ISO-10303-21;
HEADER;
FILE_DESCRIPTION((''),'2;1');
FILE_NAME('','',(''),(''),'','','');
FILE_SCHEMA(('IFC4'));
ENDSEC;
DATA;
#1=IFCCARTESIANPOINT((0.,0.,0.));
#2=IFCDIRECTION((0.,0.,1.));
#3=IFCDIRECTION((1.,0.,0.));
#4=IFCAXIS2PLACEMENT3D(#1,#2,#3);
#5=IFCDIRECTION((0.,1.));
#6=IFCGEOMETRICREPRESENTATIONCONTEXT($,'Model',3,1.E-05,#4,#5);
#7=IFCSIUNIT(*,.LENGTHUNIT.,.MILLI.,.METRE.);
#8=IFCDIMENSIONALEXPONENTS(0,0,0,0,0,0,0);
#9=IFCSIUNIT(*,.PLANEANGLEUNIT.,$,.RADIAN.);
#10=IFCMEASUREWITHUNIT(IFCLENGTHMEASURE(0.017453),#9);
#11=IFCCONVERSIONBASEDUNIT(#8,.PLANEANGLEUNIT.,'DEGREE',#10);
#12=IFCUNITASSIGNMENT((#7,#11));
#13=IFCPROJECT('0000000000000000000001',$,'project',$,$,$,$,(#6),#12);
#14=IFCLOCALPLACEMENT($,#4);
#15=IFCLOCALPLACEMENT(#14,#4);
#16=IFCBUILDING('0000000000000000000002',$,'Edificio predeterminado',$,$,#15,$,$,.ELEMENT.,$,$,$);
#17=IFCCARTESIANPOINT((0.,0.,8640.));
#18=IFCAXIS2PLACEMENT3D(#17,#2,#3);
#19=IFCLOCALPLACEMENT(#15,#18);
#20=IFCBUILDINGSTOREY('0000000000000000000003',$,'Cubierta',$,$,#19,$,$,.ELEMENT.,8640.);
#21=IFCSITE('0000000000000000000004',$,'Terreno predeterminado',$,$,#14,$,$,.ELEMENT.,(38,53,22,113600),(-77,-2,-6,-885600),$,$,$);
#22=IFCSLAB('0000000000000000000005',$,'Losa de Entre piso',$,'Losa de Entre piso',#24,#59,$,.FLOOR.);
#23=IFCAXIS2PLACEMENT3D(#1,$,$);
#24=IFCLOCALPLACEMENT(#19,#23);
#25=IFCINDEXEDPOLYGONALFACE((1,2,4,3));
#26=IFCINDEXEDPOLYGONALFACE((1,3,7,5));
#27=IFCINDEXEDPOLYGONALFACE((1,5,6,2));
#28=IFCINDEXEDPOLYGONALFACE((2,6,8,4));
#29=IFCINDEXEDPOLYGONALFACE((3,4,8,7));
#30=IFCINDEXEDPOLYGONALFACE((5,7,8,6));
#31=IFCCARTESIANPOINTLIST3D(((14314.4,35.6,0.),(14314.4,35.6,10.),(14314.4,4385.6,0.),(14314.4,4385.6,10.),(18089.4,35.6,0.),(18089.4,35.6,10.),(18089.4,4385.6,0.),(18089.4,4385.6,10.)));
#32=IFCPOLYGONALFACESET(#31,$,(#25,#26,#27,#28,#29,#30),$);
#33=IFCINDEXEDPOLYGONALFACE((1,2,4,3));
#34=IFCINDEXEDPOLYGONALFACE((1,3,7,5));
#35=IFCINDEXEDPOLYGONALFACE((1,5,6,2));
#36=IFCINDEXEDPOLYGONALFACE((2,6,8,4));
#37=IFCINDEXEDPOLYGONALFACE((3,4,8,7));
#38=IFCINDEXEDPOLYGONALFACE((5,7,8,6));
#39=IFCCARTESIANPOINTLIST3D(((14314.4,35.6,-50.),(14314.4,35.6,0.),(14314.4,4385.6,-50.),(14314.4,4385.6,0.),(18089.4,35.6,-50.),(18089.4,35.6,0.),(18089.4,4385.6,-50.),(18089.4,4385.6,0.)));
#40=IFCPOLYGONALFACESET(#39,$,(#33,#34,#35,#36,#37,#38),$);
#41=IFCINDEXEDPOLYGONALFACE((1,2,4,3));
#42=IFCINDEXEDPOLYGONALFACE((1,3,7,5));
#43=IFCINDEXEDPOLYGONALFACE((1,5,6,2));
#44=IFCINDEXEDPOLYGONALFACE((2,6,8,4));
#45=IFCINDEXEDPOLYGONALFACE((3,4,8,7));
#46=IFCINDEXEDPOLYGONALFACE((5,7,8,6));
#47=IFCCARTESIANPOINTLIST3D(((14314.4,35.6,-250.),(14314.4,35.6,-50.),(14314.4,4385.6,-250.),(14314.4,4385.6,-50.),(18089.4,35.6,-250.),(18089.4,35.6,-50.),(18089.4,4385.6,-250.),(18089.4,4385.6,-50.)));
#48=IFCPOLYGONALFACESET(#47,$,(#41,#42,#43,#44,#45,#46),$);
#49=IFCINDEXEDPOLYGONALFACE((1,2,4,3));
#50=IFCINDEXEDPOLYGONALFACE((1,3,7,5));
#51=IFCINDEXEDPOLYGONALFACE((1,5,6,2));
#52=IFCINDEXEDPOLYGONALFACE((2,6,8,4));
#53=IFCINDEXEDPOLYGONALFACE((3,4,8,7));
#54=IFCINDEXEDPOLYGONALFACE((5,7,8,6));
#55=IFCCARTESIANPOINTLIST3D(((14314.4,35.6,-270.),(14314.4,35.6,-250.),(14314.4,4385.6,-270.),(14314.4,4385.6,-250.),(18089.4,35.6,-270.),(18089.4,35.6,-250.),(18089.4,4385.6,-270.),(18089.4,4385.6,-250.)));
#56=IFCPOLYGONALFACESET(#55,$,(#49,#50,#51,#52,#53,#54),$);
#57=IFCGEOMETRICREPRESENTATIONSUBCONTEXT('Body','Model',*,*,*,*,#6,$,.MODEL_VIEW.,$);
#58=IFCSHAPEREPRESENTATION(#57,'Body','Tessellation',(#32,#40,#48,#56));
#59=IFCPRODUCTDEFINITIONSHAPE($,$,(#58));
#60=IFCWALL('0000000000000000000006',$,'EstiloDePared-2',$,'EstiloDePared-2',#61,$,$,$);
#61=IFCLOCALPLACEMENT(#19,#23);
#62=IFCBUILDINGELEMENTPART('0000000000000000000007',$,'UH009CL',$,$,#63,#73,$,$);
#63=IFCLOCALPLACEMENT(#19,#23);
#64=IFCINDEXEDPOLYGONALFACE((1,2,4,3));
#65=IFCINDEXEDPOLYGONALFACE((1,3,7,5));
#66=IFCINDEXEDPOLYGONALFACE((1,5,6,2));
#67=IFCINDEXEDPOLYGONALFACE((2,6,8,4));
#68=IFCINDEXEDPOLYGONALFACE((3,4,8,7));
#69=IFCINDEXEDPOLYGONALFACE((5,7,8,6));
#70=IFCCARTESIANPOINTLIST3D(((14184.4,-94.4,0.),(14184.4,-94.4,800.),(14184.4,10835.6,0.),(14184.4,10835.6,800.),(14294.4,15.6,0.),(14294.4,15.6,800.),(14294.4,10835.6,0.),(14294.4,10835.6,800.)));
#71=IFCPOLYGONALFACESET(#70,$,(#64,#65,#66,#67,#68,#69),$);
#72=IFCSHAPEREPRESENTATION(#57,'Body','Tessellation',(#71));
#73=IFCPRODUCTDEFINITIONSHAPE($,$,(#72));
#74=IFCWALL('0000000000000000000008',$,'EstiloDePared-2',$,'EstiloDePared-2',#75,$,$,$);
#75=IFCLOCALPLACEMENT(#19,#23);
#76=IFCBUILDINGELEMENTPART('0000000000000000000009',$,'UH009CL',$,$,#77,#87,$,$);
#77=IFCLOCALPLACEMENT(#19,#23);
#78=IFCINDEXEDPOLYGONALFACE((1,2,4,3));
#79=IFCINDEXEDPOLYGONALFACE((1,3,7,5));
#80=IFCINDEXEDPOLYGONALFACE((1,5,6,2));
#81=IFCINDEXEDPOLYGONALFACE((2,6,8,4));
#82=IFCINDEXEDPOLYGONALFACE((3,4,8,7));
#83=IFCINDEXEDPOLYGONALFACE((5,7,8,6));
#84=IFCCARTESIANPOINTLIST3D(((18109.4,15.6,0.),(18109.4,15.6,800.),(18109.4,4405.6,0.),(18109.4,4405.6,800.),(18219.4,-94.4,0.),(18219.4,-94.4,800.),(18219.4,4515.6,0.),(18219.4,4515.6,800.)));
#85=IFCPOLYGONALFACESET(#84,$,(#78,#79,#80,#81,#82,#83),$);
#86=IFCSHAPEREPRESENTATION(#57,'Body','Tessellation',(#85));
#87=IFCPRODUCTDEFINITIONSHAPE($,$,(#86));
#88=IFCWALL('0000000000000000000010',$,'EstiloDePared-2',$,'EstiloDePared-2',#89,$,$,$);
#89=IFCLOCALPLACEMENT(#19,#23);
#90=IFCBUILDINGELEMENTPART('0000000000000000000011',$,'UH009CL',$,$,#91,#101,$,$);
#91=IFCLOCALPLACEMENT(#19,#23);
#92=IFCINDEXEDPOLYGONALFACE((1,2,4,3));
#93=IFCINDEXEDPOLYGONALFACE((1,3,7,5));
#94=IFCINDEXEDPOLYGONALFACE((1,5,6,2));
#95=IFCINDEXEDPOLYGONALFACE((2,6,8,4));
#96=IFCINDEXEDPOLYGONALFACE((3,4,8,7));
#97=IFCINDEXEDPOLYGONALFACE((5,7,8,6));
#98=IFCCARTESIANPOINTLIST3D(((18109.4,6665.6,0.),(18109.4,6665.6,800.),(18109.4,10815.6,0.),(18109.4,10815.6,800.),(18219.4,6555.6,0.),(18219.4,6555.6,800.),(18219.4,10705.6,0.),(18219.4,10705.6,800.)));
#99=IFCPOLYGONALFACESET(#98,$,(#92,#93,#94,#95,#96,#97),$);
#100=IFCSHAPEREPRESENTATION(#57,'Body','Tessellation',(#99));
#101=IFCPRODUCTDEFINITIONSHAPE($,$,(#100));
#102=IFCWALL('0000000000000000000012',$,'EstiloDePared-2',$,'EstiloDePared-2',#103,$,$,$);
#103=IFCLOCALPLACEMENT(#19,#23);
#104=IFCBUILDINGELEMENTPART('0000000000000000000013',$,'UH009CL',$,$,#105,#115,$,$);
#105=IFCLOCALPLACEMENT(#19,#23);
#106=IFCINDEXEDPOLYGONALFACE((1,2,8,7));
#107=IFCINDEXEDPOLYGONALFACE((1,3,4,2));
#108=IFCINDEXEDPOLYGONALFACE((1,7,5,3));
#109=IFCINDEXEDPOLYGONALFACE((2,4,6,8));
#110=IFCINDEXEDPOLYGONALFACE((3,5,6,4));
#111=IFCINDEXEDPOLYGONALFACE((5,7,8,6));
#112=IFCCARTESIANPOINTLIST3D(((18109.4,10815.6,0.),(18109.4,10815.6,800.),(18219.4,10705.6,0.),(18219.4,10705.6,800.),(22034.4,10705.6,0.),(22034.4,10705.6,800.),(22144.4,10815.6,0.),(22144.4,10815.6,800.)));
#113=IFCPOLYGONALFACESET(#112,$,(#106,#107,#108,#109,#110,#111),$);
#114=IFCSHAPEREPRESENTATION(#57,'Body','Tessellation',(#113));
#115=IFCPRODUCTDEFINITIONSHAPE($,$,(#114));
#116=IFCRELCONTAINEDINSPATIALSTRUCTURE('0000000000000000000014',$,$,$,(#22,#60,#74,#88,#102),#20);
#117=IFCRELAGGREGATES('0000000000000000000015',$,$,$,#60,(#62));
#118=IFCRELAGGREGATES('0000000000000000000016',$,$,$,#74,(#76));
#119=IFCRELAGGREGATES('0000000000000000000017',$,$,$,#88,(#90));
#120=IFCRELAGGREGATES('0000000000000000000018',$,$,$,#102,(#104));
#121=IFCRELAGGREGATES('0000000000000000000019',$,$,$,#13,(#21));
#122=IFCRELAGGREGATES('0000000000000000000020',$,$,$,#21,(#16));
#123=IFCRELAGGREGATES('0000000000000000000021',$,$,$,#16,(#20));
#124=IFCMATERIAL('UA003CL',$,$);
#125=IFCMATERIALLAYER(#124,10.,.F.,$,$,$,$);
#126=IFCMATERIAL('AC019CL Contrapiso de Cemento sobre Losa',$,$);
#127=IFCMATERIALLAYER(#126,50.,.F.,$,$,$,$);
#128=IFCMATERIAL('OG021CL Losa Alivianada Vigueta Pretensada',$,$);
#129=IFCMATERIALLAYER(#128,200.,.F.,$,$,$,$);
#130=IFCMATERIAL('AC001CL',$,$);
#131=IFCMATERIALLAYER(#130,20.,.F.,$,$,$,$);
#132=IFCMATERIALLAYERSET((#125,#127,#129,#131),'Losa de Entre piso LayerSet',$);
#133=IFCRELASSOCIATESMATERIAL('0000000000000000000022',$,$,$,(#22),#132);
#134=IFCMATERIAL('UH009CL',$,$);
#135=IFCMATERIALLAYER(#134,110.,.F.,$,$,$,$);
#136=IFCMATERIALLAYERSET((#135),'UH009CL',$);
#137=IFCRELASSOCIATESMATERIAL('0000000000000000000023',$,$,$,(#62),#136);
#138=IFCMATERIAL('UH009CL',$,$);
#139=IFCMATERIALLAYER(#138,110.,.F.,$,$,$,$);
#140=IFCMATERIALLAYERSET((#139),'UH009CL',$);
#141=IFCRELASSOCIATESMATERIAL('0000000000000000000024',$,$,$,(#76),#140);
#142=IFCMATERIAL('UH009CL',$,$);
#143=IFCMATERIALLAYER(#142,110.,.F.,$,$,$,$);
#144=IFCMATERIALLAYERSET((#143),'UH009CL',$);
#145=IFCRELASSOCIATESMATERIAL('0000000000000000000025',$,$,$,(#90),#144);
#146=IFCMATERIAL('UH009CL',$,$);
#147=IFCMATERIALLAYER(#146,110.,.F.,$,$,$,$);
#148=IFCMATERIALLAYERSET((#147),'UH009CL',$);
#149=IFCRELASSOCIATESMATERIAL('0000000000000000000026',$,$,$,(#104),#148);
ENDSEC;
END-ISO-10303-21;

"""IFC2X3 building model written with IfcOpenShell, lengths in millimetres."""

from ifc_helpers import new_model, entity, si_unit, converted_unit, direction, frame, origin_with_axes, place, context, subcontext, project, spatial, polyline, outline, extrude, material, layer, layer_set, layer_usage, element, aggregate, save


model = new_model("IFC2X3")

# Units and contexts
model_context = context("Model", 3, precision=1e-05, world=origin_with_axes(), true_north=direction((0.0, 1.0)))
body_context = subcontext(model_context, "Body", "Model", "MODEL_VIEW")
ifc_project = project(units=[si_unit("LENGTHUNIT", "METRE", prefix="MILLI"), converted_unit("PLANEANGLEUNIT", "DEGREE", entity("IfcLengthMeasure", 0.017453), si_unit("PLANEANGLEUNIT", "RADIAN"), dimensions=[0, 0, 0, 0, 0, 0, 0])], contexts=[model_context])

# Site, building, storey
site_placement = place(None, origin_with_axes())
site = spatial("IfcSite", under=ifc_project, at=site_placement, Name="Terreno predeterminado", CompositionType="ELEMENT", RefLatitude=(38, 53, 22, 113600), RefLongitude=(-77, -2, -6, -885600))
building_placement = place(site_placement, origin_with_axes())
building = spatial("IfcBuilding", under=site, at=building_placement, Name="Edificio predeterminado", CompositionType="ELEMENT")
storey_placement = place(building_placement, frame((0.0, 0.0, 8640.0), z_axis=(0.0, 0.0, 1.0), x_axis=(1.0, 0.0, 0.0)))
storey = spatial("IfcBuildingStorey", under=building, at=storey_placement, Name="Cubierta", CompositionType="ELEMENT", Elevation=8640.0)

# Slab
ifc_material_1 = material(Name="UA003CL")
ifc_layer_1 = layer(ifc_material_1, 10.0, ventilated=False)
ifc_material_2 = material(Name="AC019CL Contrapiso de Cemento sobre Losa")
ifc_layer_2 = layer(ifc_material_2, 50.0, ventilated=False)
ifc_material_3 = material(Name="OG021CL Losa Alivianada Vigueta Pretensada")
ifc_layer_3 = layer(ifc_material_3, 200.0, ventilated=False)
ifc_material_4 = material(Name="AC001CL")
ifc_layer_4 = layer(ifc_material_4, 20.0, ventilated=False)
ifc_layer_set_1 = layer_set([ifc_layer_1, ifc_layer_2, ifc_layer_3, ifc_layer_4], Name="Losa de Entre piso LayerSet")
ifc_layer_usage_1 = layer_usage(ifc_layer_set_1, "AXIS3", "NEGATIVE", 0.0)
slab_1_placement = place(storey_placement, frame((0.0, 0.0, -8640.0), z_axis=(0.0, 0.0, 1.0), x_axis=(1.0, 0.0, 0.0)))
element("IfcSlab", 1, at=slab_1_placement, inside=storey, material=ifc_layer_usage_1, Name="Losa de Entre piso", ObjectType="Losa de Entre piso", PredefinedType="FLOOR", context=body_context, shape_type="SweptSolid", body=[
    extrude(outline(polyline([(0.0, 4350.0), (3775.0, 4350.0), (3775.0, 0.0), (0.0, 0.0), (0.0, 4350.0)])), frame((18089.4, 35.6, 8640.0), z_axis=(0.0, 0.0, -1.0), x_axis=(-1.0, 0.0, 0.0)), (0.0, 0.0, -1.0), 10.0),
    extrude(outline(polyline([(0.0, 4350.0), (3775.0, 4350.0), (3775.0, 0.0), (0.0, 0.0), (0.0, 4350.0)])), frame((18089.4, 35.6, 8590.0), z_axis=(0.0, 0.0, -1.0), x_axis=(-1.0, 0.0, 0.0)), (0.0, 0.0, -1.0), 50.0),
    extrude(outline(polyline([(0.0, 4350.0), (3775.0, 4350.0), (3775.0, 0.0), (0.0, 0.0), (0.0, 4350.0)])), frame((18089.4, 35.6, 8390.0), z_axis=(0.0, 0.0, -1.0), x_axis=(-1.0, 0.0, 0.0)), (0.0, 0.0, -1.0), 200.0),
    extrude(outline(polyline([(0.0, 4350.0), (3775.0, 4350.0), (3775.0, 0.0), (0.0, 0.0), (0.0, 4350.0)])), frame((18089.4, 35.6, 8370.0), z_axis=(0.0, 0.0, -1.0), x_axis=(-1.0, 0.0, 0.0)), (0.0, 0.0, -1.0), 20.0),
])

# Walls, building element parts
wall_1_placement = place(storey_placement, frame((14239.4, -39.4, 0.0), z_axis=(0.0, 0.0, 1.0), x_axis=(0.0, 1.0, 0.0)))
wall_1 = element("IfcWall", 2, at=wall_1_placement, inside=storey, Name="EstiloDePared-2", ObjectType="EstiloDePared-2")
ifc_material_5 = material(Name="UH009CL")
ifc_layer_5 = layer(ifc_material_5, 110.0, ventilated=False)
ifc_layer_set_2 = layer_set([ifc_layer_5], Name="UH009CL")
ifc_layer_usage_2 = layer_usage(ifc_layer_set_2, "AXIS2", "NEGATIVE", -55.0)
building_element_part_1_placement = place(wall_1_placement, origin_with_axes())
building_element_part_1 = element("IfcBuildingElementPart", 3, at=building_element_part_1_placement, material=ifc_layer_usage_2, Name="UH009CL", context=body_context, shape_type="SweptSolid", body=[
    extrude(outline(polyline([(10875.0, 55.0), (10875.0, -55.0), (55.0, -55.0), (-55.0, 55.0), (10875.0, 55.0)])), origin_with_axes(), (0.0, 0.0, 1.0), 800.0),
])
aggregate(wall_1, [building_element_part_1])
wall_2_placement = place(storey_placement, frame((18164.4, -39.4, 0.0), z_axis=(0.0, 0.0, 1.0), x_axis=(0.0, 1.0, 0.0)))
wall_2 = element("IfcWall", 4, at=wall_2_placement, inside=storey, Name="EstiloDePared-2", ObjectType="EstiloDePared-2")
ifc_material_6 = material(Name="UH009CL")
ifc_layer_6 = layer(ifc_material_6, 110.0, ventilated=False)
ifc_layer_set_3 = layer_set([ifc_layer_6], Name="UH009CL")
ifc_layer_usage_3 = layer_usage(ifc_layer_set_3, "AXIS2", "NEGATIVE", -55.0)
building_element_part_2_placement = place(wall_2_placement, origin_with_axes())
building_element_part_2 = element("IfcBuildingElementPart", 5, at=building_element_part_2_placement, material=ifc_layer_usage_3, Name="UH009CL", context=body_context, shape_type="SweptSolid", body=[
    extrude(outline(polyline([(4445.0, 55.0), (4555.0, -55.0), (-55.0, -55.0), (55.0, 55.0), (4445.0, 55.0)])), origin_with_axes(), (0.0, 0.0, 1.0), 800.0),
])
aggregate(wall_2, [building_element_part_2])
wall_3_placement = place(storey_placement, frame((18164.4, 6610.6, 0.0), z_axis=(0.0, 0.0, 1.0), x_axis=(0.0, 1.0, 0.0)))
wall_3 = element("IfcWall", 6, at=wall_3_placement, inside=storey, Name="EstiloDePared-2", ObjectType="EstiloDePared-2")
ifc_material_7 = material(Name="UH009CL")
ifc_layer_7 = layer(ifc_material_7, 110.0, ventilated=False)
ifc_layer_set_4 = layer_set([ifc_layer_7], Name="UH009CL")
ifc_layer_usage_4 = layer_usage(ifc_layer_set_4, "AXIS2", "NEGATIVE", -55.0)
building_element_part_3_placement = place(wall_3_placement, origin_with_axes())
building_element_part_3 = element("IfcBuildingElementPart", 7, at=building_element_part_3_placement, material=ifc_layer_usage_4, Name="UH009CL", context=body_context, shape_type="SweptSolid", body=[
    extrude(outline(polyline([(4205.0, 55.0), (4095.0, -55.0), (-55.0, -55.0), (55.0, 55.0), (4205.0, 55.0)])), origin_with_axes(), (0.0, 0.0, 1.0), 800.0),
])
aggregate(wall_3, [building_element_part_3])
wall_4_placement = place(storey_placement, frame((18164.4, 10760.6, 0.0), z_axis=(0.0, 0.0, 1.0), x_axis=(1.0, 0.0, 0.0)))
wall_4 = element("IfcWall", 8, at=wall_4_placement, inside=storey, Name="EstiloDePared-2", ObjectType="EstiloDePared-2")
ifc_material_8 = material(Name="UH009CL")
ifc_layer_8 = layer(ifc_material_8, 110.0, ventilated=False)
ifc_layer_set_5 = layer_set([ifc_layer_8], Name="UH009CL")
ifc_layer_usage_5 = layer_usage(ifc_layer_set_5, "AXIS2", "NEGATIVE", -55.0)
building_element_part_4_placement = place(wall_4_placement, origin_with_axes())
building_element_part_4 = element("IfcBuildingElementPart", 9, at=building_element_part_4_placement, material=ifc_layer_usage_5, Name="UH009CL", context=body_context, shape_type="SweptSolid", body=[
    extrude(outline(polyline([(3980.0, 55.0), (3870.0, -55.0), (55.0, -55.0), (-55.0, 55.0), (3980.0, 55.0)])), origin_with_axes(), (0.0, 0.0, 1.0), 800.0),
])
aggregate(wall_4, [building_element_part_4])

save(model, "model.ifc")
